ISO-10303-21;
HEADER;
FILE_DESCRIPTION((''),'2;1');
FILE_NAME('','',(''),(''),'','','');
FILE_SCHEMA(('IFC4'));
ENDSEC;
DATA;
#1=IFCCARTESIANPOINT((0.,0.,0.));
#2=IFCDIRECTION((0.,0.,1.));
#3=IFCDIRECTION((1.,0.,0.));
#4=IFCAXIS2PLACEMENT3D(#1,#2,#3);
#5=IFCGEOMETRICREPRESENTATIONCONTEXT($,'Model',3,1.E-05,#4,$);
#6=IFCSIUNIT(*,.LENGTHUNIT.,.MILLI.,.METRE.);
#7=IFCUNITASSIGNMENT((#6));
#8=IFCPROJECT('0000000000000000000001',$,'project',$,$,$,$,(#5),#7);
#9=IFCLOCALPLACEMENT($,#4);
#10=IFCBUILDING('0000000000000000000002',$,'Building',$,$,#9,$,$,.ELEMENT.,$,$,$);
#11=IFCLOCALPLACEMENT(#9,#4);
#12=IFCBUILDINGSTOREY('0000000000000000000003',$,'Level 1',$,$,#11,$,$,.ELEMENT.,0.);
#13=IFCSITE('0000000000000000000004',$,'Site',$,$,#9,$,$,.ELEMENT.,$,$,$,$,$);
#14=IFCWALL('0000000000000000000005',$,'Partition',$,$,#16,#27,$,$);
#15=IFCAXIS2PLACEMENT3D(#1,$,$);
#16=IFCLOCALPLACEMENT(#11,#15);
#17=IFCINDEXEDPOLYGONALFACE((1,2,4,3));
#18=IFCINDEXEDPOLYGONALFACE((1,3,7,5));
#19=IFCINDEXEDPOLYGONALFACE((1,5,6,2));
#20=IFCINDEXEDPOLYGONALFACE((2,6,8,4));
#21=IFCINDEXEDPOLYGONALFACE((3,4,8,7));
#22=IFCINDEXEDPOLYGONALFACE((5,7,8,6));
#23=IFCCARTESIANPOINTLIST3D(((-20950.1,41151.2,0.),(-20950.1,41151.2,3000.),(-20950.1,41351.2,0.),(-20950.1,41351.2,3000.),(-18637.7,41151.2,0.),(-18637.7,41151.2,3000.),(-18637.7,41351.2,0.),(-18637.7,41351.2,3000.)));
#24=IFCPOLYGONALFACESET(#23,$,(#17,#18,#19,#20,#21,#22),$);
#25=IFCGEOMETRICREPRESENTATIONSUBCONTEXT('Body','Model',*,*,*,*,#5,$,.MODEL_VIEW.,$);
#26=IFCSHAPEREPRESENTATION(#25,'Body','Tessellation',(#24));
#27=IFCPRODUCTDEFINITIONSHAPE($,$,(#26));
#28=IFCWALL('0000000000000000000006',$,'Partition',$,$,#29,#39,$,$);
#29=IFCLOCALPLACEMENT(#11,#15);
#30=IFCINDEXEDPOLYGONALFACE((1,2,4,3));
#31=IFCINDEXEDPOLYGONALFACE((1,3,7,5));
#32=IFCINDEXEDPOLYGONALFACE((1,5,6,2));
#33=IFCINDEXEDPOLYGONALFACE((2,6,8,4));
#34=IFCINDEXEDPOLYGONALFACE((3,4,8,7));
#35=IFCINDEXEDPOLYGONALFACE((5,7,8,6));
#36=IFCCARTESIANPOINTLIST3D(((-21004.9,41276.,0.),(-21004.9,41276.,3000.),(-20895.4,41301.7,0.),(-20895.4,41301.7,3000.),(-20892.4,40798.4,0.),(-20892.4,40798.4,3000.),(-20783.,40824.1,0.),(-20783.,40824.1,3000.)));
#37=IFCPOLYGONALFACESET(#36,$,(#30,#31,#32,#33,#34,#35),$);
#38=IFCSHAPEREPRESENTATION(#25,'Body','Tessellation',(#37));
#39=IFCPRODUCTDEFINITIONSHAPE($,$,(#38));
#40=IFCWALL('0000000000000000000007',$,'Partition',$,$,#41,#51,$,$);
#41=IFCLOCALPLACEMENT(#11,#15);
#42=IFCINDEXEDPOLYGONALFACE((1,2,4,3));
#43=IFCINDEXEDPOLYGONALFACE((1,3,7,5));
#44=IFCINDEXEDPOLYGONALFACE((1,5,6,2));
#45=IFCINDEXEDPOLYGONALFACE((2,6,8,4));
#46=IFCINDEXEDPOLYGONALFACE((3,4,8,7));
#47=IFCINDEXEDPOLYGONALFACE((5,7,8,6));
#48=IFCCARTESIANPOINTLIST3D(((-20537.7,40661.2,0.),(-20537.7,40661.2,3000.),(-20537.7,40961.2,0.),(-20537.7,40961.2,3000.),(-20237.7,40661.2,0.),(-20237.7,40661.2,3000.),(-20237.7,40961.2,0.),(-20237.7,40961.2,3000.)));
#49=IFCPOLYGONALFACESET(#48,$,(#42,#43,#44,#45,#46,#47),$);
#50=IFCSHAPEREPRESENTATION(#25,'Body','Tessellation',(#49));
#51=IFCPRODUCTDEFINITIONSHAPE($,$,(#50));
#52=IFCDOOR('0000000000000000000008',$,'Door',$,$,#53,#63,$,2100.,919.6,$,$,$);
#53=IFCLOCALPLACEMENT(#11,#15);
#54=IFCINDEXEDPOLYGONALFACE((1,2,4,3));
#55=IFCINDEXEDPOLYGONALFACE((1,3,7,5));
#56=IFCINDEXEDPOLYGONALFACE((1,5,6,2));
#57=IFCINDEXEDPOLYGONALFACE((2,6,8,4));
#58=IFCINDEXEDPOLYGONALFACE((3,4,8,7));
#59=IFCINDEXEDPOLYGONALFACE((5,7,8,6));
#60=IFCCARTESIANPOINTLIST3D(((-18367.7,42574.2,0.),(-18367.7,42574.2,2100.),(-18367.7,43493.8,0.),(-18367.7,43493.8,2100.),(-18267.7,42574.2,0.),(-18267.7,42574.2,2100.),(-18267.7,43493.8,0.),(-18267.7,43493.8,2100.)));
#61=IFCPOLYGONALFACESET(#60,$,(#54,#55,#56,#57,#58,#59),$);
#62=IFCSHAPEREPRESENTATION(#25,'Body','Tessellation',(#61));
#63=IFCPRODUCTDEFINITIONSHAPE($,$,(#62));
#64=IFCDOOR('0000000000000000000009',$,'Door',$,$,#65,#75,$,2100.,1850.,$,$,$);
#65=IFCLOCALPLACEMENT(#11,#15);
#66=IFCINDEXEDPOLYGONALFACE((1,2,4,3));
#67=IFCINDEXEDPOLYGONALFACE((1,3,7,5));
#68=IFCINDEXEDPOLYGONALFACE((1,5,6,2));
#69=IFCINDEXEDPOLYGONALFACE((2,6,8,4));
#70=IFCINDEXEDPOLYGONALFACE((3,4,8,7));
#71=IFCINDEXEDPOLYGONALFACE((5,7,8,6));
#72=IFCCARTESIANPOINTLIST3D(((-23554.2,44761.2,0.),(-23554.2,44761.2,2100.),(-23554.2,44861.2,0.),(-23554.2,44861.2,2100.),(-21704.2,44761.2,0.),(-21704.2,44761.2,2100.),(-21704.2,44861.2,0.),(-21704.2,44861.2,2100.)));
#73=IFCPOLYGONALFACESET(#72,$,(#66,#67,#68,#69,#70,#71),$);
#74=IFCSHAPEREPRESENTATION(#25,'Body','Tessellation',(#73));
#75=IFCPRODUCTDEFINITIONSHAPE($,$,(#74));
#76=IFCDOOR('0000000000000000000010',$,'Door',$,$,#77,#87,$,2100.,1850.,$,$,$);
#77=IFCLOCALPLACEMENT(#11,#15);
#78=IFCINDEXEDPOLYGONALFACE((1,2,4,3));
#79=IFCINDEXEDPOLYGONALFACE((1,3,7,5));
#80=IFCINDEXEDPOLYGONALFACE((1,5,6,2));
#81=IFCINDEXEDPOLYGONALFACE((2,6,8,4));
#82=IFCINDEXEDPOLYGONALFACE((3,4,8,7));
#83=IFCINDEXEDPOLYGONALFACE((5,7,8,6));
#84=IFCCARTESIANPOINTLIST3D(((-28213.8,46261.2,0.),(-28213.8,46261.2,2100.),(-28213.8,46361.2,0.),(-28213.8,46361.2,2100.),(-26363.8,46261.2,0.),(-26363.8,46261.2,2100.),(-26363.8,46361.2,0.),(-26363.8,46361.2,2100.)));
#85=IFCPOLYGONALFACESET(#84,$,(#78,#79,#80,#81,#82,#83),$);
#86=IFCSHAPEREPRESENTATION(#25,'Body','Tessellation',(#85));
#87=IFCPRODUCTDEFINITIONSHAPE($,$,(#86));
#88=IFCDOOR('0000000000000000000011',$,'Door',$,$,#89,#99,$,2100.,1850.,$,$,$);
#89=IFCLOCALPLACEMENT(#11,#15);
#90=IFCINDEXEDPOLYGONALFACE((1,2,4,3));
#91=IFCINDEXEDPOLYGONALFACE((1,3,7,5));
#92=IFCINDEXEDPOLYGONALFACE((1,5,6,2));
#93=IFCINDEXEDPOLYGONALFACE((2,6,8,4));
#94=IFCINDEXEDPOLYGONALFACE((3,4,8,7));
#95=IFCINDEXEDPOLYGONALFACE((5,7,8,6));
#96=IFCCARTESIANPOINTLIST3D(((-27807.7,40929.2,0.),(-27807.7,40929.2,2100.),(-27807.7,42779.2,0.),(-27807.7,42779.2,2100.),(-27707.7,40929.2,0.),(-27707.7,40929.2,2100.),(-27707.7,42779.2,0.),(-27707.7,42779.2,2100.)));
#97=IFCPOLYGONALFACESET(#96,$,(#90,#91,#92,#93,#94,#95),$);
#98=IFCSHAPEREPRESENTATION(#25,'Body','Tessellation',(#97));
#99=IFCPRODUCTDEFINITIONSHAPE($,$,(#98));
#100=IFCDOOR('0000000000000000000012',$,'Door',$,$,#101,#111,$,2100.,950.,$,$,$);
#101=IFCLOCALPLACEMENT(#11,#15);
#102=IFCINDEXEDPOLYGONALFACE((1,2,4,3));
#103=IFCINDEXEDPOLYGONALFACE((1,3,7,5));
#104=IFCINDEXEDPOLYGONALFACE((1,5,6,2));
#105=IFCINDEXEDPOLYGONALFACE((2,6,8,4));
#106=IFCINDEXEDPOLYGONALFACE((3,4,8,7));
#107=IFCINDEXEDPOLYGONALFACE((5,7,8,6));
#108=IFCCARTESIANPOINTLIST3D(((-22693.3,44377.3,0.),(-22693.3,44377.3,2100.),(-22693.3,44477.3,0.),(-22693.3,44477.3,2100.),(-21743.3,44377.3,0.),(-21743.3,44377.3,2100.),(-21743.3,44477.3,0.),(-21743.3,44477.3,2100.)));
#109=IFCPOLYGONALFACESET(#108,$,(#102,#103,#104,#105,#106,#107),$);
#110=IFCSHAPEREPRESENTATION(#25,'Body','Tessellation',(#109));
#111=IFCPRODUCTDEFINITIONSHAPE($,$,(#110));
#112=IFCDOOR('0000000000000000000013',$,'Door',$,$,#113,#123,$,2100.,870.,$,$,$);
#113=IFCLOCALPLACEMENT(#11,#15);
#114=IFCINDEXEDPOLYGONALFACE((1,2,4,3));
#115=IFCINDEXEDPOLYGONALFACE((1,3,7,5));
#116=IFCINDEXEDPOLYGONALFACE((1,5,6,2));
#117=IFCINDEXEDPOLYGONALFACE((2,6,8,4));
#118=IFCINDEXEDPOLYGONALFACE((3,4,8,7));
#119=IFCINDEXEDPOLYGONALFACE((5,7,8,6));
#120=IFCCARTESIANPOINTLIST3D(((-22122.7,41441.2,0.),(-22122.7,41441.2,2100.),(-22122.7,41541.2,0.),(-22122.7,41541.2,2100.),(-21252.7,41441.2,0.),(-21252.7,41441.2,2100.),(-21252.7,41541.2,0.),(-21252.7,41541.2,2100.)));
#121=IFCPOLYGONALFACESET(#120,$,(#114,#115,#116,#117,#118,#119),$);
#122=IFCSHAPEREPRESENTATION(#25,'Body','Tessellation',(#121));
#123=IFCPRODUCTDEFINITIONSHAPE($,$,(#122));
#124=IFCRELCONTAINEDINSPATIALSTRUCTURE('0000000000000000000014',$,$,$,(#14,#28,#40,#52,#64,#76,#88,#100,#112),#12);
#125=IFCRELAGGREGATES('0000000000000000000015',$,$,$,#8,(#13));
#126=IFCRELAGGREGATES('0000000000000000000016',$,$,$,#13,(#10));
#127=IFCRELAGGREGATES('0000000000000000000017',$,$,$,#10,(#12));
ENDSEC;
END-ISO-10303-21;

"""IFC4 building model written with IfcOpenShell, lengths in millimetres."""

from ifc_helpers import new_model, si_unit, frame, frame_2d, origin_with_axes, place, context, subcontext, project, spatial, rectangle, extrude, element, save


model = new_model("IFC4")

# Units and contexts
model_context = context("Model", 3, precision=1e-05, world=origin_with_axes())
body_context = subcontext(model_context, "Body", "Model", "MODEL_VIEW")
ifc_project = project(units=[si_unit("LENGTHUNIT", "METRE", prefix="MILLI")], contexts=[model_context])

# Site, building, storey
placement = place(None, origin_with_axes())
site = spatial("IfcSite", under=ifc_project, at=placement, Name="Site", CompositionType="ELEMENT")
building = spatial("IfcBuilding", under=site, at=placement, Name="Building", CompositionType="ELEMENT")
storey_placement = place(placement, origin_with_axes())
storey = spatial("IfcBuildingStorey", under=building, at=storey_placement, Name="Level 1", CompositionType="ELEMENT", Elevation=0.0)

# Walls
wall_1_placement = place(placement, frame((-20950.1, 41251.2, 0.0), z_axis=(0.0, 0.0, 1.0), x_axis=(1.0, 0.0, 0.0)))
element("IfcWall", 1, at=wall_1_placement, inside=storey, Name="Partition", context=body_context, shape_type="SweptSolid", body=[
    extrude(rectangle(XDim=2312.5, YDim=200.0, at=frame_2d((1156.2, 0.0), x_axis=(1.0, 0.0))), origin_with_axes(), (0.0, 0.0, 1.0), 3000.0),
])
wall_2_placement = place(placement, frame((-20950.1, 41288.9, 0.0), z_axis=(0.0, 0.0, 1.0), x_axis=(0.229198, -0.97338, 0.0)))
element("IfcWall", 2, at=wall_2_placement, inside=storey, Name="Partition", context=body_context, shape_type="SweptSolid", body=[
    extrude(rectangle(XDim=490.7, YDim=112.5, at=frame_2d((245.3, 0.0), x_axis=(1.0, 0.0))), origin_with_axes(), (0.0, 0.0, 1.0), 3000.0),
])
wall_3_placement = place(placement, frame((-20237.7, 40811.2, 0.0), z_axis=(0.0, 0.0, 1.0), x_axis=(-1.0, 0.0, 0.0)))
element("IfcWall", 3, at=wall_3_placement, inside=storey, Name="Partition", context=body_context, shape_type="SweptSolid", body=[
    extrude(rectangle(XDim=300.0, YDim=300.0, at=frame_2d((150.0, 0.0), x_axis=(1.0, 0.0))), origin_with_axes(), (0.0, 0.0, 1.0), 3000.0),
])

# Doors
door_1_placement = place(placement, frame((-18317.7, 42574.2, 0.0), z_axis=(0.0, 0.0, 1.0), x_axis=(0.0, 1.0, 0.0)))
element("IfcDoor", 4, at=door_1_placement, inside=storey, Name="Door", OverallHeight=2100.0, OverallWidth=919.6, context=body_context, shape_type="SweptSolid", body=[
    extrude(rectangle(XDim=919.6, YDim=100.0, at=frame_2d((459.8, 0.0), x_axis=(1.0, 0.0))), origin_with_axes(), (0.0, 0.0, 1.0), 2100.0),
])
for number, where, z_axis, x_axis, name in (
    (5, (-21704.2, 44811.2, 0.0), (0.0, 0.0, 1.0), (-1.0, 0.0, 0.0), "Door"),
    (6, (-26363.8, 46311.2, 0.0), (0.0, 0.0, 1.0), (-1.0, 0.0, 0.0), "Door"),
    (7, (-27757.7, 42779.2, 0.0), (0.0, 0.0, 1.0), (0.0, -1.0, 0.0), "Door"),
):
    element("IfcDoor", number, at=place(placement, frame(where, z_axis=z_axis, x_axis=x_axis)), inside=storey, Name=name, OverallHeight=2100.0, OverallWidth=1850.0, context=body_context, shape_type="SweptSolid", body=[
        extrude(rectangle(XDim=1850.0, YDim=100.0, at=frame_2d((925.0, 0.0), x_axis=(1.0, 0.0))), origin_with_axes(), (0.0, 0.0, 1.0), 2100.0),
    ])
door_2_placement = place(placement, frame((-21743.3, 44427.3, 0.0), z_axis=(0.0, 0.0, 1.0), x_axis=(-1.0, 0.0, 0.0)))
element("IfcDoor", 8, at=door_2_placement, inside=storey, Name="Door", OverallHeight=2100.0, OverallWidth=950.0, context=body_context, shape_type="SweptSolid", body=[
    extrude(rectangle(XDim=950.0, YDim=100.0, at=frame_2d((475.0, 0.0), x_axis=(1.0, 0.0))), origin_with_axes(), (0.0, 0.0, 1.0), 2100.0),
])
door_3_placement = place(placement, frame((-22122.7, 41491.2, 0.0), z_axis=(0.0, 0.0, 1.0), x_axis=(1.0, 0.0, 0.0)))
element("IfcDoor", 9, at=door_3_placement, inside=storey, Name="Door", OverallHeight=2100.0, OverallWidth=870.0, context=body_context, shape_type="SweptSolid", body=[
    extrude(rectangle(XDim=870.0, YDim=100.0, at=frame_2d((435.0, 0.0), x_axis=(1.0, 0.0))), origin_with_axes(), (0.0, 0.0, 1.0), 2100.0),
])

save(model, "model.ifc")
